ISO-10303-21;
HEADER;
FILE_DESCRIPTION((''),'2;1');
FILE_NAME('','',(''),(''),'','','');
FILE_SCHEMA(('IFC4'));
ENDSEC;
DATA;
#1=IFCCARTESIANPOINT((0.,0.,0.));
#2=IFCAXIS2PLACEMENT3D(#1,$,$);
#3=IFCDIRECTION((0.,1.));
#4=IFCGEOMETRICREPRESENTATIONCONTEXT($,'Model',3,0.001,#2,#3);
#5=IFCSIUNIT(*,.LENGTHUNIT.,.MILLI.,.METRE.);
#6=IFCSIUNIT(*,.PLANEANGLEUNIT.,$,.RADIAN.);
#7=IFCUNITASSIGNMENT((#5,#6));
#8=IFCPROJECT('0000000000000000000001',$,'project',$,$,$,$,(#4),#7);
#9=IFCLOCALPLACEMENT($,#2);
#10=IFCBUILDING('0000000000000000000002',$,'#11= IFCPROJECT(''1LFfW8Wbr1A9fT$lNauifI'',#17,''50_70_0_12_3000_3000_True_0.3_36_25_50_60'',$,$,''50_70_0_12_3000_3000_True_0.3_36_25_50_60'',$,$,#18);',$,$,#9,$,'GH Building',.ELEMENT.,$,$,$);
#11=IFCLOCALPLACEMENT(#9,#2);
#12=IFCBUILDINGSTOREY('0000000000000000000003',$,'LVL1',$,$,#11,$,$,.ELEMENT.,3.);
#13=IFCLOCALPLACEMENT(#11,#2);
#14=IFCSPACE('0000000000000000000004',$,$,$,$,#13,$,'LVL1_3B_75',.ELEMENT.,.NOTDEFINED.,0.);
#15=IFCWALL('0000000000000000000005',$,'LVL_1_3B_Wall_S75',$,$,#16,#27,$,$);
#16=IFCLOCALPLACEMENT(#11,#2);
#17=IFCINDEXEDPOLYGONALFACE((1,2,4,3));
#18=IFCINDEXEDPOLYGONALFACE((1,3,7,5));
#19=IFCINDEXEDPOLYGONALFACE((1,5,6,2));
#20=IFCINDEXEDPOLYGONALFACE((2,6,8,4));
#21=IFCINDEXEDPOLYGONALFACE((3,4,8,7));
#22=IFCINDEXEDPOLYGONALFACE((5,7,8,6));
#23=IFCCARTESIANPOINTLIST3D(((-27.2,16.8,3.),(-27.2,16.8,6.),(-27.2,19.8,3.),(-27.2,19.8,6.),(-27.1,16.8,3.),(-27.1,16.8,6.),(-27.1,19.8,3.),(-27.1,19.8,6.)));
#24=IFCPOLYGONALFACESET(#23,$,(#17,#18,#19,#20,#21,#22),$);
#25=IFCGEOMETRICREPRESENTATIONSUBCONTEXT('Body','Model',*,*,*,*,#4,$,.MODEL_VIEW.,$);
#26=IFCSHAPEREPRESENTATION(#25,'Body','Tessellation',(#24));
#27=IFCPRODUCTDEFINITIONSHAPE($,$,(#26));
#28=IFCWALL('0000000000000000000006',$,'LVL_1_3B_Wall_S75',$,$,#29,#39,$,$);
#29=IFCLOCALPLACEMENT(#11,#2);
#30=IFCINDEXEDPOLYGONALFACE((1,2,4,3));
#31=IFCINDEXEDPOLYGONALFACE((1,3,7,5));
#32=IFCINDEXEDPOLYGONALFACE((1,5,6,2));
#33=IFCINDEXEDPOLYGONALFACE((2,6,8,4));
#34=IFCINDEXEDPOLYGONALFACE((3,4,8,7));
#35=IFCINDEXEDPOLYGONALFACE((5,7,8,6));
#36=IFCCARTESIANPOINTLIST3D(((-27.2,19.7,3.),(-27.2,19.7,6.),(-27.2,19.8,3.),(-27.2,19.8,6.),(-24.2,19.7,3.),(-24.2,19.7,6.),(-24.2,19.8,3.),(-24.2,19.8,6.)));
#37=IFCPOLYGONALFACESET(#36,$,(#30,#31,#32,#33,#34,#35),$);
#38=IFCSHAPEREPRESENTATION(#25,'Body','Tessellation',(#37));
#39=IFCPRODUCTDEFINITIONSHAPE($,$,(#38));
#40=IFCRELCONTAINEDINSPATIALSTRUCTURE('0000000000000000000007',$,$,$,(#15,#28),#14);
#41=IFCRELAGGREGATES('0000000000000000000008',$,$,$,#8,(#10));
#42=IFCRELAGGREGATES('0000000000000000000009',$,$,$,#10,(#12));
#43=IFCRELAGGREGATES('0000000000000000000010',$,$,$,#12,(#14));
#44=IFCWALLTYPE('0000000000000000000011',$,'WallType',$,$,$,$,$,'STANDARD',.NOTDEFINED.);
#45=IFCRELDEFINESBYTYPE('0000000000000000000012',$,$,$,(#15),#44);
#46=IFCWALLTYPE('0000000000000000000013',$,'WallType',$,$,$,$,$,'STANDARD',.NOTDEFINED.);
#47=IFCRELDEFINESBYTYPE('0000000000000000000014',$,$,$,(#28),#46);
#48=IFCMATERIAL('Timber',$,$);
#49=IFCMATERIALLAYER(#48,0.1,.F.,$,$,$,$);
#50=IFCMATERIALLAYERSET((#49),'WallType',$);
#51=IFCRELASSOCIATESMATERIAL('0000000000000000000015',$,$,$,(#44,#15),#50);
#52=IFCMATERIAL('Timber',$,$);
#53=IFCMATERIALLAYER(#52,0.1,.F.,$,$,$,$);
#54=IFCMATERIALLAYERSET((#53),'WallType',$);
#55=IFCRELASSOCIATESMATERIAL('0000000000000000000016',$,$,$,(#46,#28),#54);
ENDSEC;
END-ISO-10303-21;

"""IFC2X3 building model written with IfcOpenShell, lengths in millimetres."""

from ifc_helpers import new_model, si_unit, direction, frame, frame_2d, origin, place, context, subcontext, project, spatial, rectangle, extrude, material, layer, layer_set, layer_usage, type_object, element, save


model = new_model("IFC2X3")

# Units and contexts
model_context = context("Model", 3, precision=0.001, world=origin(), true_north=direction((0.0, 1.0)))
body_context = subcontext(model_context, "Body", "Model", "MODEL_VIEW")
ifc_project = project(units=[si_unit("LENGTHUNIT", "METRE", prefix="MILLI"), si_unit("PLANEANGLEUNIT", "RADIAN")], contexts=[model_context])

# Building, storey
building_placement = place(None, origin())
building = spatial("IfcBuilding", under=ifc_project, at=building_placement, Name="#11= IFCPROJECT('1LFfW8Wbr1A9fT$lNauifI',#17,'50_70_0_12_3000_3000_True_0.3_36_25_50_60',$,$,'50_70_0_12_3000_3000_True_0.3_36_25_50_60',$,$,#18);", LongName="GH Building", CompositionType="ELEMENT")
storey_placement = place(building_placement, origin())
storey = spatial("IfcBuildingStorey", under=building, at=storey_placement, Name="LVL1", CompositionType="ELEMENT", Elevation=3.0)

# Shared definitions
space_1_placement = place(storey_placement, origin())
space_1 = spatial("IfcSpace", under=storey, at=space_1_placement, LongName="LVL1_3B_75", CompositionType="ELEMENT", InteriorOrExteriorSpace="NOTDEFINED", ElevationWithFlooring=0.0)

# Walls
ifc_material_1 = material(Name="Timber")
ifc_layer_1 = layer(ifc_material_1, 0.1, ventilated=False)
ifc_layer_set_1 = layer_set([ifc_layer_1], Name="WallType")
ifc_layer_usage_1 = layer_usage(ifc_layer_set_1, "AXIS2", "NEGATIVE", 0.0)
wall_type_1 = type_object("IfcWallType", Name="WallType", ElementType="STANDARD", PredefinedType="NOTDEFINED", material=ifc_layer_set_1)
wall_1_placement = place(space_1_placement, frame((-27.2, 16.8, 3.0), z_axis=(0.0, 0.0, 1.0), x_axis=(0.0, 1.0, 0.0)))
element("IfcWall", 1, at=wall_1_placement, inside=space_1, type_object=wall_type_1, material=ifc_layer_usage_1, Name="LVL_1_3B_Wall_S75", context=body_context, shape_type="SweptSolid", body=[
    extrude(rectangle(XDim=3.0, YDim=0.1, at=frame_2d((1.5, -0.1))), origin(), (0.0, 0.0, 1.0), 3.0),
])
ifc_material_2 = material(Name="Timber")
ifc_layer_2 = layer(ifc_material_2, 0.1, ventilated=False)
ifc_layer_set_2 = layer_set([ifc_layer_2], Name="WallType")
ifc_layer_usage_2 = layer_usage(ifc_layer_set_2, "AXIS2", "NEGATIVE", 0.0)
wall_type_2 = type_object("IfcWallType", Name="WallType", ElementType="STANDARD", PredefinedType="NOTDEFINED", material=ifc_layer_set_2)
wall_2_placement = place(space_1_placement, frame((-27.2, 19.8, 3.0)))
element("IfcWall", 2, at=wall_2_placement, inside=space_1, type_object=wall_type_2, material=ifc_layer_usage_2, Name="LVL_1_3B_Wall_S75", context=body_context, shape_type="SweptSolid", body=[
    extrude(rectangle(XDim=3.0, YDim=0.1, at=frame_2d((1.5, -0.1))), origin(), (0.0, 0.0, 1.0), 3.0),
])

save(model, "model.ifc")
